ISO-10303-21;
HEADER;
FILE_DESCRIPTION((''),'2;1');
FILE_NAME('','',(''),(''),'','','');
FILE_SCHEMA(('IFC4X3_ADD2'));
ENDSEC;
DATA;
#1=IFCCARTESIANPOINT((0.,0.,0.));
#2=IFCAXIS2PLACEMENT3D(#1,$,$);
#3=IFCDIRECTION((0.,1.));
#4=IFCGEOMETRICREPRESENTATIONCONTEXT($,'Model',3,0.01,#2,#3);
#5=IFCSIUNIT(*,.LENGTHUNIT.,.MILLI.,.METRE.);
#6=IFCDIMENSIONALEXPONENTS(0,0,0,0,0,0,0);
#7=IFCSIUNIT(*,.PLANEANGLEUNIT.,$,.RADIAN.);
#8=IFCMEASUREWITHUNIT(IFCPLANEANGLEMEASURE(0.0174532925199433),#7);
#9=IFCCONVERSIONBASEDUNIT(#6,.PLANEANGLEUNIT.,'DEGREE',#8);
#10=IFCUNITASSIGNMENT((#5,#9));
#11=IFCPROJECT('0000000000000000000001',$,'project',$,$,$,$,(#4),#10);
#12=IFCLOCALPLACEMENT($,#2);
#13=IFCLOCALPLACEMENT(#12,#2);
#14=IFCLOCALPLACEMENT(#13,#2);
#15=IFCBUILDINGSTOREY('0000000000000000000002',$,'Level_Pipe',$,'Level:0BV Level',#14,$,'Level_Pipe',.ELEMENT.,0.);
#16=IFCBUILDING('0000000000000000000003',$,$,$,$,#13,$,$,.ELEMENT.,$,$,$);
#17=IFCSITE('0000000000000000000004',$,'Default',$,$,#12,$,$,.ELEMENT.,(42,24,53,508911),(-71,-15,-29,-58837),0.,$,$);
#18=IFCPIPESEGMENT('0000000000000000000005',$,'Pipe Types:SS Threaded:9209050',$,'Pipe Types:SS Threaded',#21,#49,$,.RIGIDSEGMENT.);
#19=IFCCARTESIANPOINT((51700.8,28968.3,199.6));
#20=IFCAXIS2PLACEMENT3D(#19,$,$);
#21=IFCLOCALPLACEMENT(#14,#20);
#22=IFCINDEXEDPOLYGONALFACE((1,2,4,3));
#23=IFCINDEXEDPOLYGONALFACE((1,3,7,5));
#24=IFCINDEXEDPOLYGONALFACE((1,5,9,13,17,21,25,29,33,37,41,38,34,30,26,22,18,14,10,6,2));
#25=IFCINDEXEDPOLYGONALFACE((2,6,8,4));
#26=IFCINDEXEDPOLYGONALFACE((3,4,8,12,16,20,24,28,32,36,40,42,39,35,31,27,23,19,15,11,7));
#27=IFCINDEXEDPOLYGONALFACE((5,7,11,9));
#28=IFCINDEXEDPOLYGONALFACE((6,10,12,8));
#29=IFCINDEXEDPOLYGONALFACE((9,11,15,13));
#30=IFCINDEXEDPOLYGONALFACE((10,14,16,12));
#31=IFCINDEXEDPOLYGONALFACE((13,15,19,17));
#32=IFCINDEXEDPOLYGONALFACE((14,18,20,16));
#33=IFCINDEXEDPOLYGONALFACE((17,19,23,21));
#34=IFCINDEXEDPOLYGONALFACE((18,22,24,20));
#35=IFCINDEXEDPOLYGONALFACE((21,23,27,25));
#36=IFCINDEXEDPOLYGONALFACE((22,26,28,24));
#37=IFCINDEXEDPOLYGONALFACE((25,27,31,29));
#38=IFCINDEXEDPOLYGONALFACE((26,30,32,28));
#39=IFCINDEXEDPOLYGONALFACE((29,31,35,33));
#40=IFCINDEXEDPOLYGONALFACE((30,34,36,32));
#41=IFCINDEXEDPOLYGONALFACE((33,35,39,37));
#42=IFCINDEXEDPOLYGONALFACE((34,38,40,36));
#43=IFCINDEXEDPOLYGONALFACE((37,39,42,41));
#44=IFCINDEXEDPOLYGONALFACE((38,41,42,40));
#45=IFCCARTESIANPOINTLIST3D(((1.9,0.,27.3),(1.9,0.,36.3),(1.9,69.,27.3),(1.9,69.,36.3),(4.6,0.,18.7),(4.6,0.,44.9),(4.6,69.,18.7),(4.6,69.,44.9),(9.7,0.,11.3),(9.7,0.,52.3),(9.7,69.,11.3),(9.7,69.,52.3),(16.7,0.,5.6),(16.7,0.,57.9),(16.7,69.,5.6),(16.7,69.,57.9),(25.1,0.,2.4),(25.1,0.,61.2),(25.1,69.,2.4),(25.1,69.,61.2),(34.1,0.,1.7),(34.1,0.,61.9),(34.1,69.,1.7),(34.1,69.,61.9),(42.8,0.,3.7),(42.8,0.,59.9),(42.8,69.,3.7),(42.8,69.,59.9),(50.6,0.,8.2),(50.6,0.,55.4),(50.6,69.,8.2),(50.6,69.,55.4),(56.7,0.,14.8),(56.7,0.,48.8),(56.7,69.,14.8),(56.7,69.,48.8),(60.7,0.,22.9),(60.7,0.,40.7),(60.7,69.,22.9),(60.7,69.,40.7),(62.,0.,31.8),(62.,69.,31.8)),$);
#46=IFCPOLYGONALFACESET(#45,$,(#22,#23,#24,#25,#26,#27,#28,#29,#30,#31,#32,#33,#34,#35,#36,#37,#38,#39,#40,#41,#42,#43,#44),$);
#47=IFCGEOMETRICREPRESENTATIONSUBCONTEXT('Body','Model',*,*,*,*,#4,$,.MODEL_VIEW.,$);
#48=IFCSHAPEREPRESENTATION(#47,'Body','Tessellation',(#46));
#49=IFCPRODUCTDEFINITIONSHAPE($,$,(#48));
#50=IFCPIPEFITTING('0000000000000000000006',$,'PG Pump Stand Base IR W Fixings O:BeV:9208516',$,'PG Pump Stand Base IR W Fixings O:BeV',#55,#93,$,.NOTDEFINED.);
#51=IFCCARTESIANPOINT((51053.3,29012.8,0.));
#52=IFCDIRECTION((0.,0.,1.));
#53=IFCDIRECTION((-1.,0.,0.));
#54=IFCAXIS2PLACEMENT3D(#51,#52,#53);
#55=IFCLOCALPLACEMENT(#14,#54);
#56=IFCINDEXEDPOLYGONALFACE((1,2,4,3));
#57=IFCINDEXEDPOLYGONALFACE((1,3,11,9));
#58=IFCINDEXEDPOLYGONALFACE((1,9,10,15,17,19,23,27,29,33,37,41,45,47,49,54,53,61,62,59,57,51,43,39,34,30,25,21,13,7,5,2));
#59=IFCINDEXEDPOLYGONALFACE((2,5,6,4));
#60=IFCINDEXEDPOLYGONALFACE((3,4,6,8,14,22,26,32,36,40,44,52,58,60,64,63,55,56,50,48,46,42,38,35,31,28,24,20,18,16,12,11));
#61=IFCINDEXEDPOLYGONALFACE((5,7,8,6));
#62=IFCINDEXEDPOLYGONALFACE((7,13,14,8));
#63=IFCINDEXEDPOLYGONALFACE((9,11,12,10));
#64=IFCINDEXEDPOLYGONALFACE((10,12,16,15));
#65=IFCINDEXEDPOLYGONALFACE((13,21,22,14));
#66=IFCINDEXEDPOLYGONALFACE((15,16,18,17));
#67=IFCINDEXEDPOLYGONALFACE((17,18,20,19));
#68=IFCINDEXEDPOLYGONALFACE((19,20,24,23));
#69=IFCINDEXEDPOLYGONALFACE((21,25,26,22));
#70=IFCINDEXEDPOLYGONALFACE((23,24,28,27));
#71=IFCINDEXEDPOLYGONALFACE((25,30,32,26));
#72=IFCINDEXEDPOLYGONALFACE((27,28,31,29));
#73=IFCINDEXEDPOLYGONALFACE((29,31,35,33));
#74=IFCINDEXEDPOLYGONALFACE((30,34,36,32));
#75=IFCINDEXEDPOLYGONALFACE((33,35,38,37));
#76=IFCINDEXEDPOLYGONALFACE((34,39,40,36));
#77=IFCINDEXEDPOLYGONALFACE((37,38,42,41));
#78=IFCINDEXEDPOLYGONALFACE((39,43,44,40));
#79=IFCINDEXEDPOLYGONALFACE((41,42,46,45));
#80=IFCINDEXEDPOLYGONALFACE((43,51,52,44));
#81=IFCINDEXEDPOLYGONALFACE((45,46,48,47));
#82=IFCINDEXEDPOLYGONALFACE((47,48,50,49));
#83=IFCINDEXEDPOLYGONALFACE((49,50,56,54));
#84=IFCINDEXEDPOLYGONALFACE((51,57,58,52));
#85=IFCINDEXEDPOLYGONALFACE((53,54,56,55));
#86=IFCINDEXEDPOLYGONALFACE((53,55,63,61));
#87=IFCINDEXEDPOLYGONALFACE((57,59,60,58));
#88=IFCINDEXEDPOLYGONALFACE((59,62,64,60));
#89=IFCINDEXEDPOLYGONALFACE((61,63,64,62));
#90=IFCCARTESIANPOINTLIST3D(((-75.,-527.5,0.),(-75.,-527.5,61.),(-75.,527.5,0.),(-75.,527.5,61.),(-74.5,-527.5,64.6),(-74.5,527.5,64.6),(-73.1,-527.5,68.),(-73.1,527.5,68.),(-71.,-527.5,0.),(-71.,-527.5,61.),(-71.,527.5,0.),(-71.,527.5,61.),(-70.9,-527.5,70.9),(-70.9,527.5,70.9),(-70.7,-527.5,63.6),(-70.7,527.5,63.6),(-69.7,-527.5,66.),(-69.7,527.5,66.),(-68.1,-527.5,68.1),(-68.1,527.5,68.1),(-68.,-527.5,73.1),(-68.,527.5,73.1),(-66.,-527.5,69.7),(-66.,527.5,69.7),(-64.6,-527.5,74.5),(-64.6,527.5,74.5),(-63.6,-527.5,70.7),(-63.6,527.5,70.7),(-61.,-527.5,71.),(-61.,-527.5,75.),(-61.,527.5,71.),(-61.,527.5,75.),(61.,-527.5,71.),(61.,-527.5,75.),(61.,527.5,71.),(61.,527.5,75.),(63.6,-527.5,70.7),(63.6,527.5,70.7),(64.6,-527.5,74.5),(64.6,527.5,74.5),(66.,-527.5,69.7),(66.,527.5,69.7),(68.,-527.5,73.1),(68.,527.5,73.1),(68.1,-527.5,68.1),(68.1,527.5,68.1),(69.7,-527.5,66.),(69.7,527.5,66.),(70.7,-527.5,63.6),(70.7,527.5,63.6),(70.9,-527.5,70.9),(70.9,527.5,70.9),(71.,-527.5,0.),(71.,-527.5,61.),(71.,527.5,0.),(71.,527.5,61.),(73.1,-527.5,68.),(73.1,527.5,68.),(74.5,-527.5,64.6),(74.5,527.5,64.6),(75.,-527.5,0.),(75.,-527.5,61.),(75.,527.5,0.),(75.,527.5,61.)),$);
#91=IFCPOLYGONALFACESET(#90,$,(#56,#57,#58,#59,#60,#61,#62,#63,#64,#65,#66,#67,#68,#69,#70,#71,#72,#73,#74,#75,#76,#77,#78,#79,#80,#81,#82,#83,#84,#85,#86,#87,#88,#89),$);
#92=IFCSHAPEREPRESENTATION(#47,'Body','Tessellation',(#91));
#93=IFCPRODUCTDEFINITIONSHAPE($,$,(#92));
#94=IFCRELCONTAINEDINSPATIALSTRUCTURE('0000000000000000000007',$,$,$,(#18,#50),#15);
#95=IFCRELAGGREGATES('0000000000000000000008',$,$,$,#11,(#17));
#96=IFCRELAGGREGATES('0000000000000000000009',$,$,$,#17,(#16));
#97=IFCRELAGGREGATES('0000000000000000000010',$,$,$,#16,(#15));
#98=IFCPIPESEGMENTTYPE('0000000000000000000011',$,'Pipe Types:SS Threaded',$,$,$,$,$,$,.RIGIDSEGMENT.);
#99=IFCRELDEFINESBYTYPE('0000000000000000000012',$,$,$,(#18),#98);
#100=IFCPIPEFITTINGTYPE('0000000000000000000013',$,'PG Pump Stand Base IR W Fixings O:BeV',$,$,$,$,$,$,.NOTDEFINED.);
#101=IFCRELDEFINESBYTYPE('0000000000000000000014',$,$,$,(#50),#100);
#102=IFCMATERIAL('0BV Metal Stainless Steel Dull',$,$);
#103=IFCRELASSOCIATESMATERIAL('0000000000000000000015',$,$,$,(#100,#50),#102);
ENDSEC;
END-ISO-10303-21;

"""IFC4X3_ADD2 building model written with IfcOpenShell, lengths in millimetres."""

from ifc_helpers import new_model, entity, si_unit, converted_unit, direction, frame, frame_2d, origin, place, context, subcontext, project, spatial, polyline, circle_curve, parameter, trimmed, segment, composite_curve, circle, outline, extrude, source, transform, mapped, material, type_object, type_shapes, element, save


model = new_model("IFC4X3_ADD2")

# Units and contexts
model_context = context("Model", 3, precision=0.01, world=origin(), true_north=direction((0.0, 1.0)))
body_context = subcontext(model_context, "Body", "Model", "MODEL_VIEW")
ifc_project = project(units=[si_unit("LENGTHUNIT", "METRE", prefix="MILLI"), converted_unit("PLANEANGLEUNIT", "DEGREE", entity("IfcPlaneAngleMeasure", 0.0174532925199433), si_unit("PLANEANGLEUNIT", "RADIAN"), dimensions=[0, 0, 0, 0, 0, 0, 0])], contexts=[model_context])

# Site, building, storey
site_placement = place(None, origin())
site = spatial("IfcSite", under=ifc_project, at=site_placement, Name="Default", CompositionType="ELEMENT", RefLatitude=(42, 24, 53, 508911), RefLongitude=(-71, -15, -29, -58837), RefElevation=0.0)
building_placement = place(site_placement, origin())
building = spatial("IfcBuilding", under=site, at=building_placement, CompositionType="ELEMENT")
storey_placement = place(building_placement, origin())
storey = spatial("IfcBuildingStorey", under=building, at=storey_placement, Name="Level_Pipe", ObjectType="Level:0BV Level", LongName="Level_Pipe", CompositionType="ELEMENT", Elevation=0.0)

# Pipe segment
pipe_segment_type = type_object("IfcPipeSegmentType", Name="Pipe Types:SS Threaded", PredefinedType="RIGIDSEGMENT")
pipe_segment_placement = place(storey_placement, frame((51700.8, 28968.3, 199.6)))
element("IfcPipeSegment", 1, at=pipe_segment_placement, inside=storey, type_object=pipe_segment_type, Name="Pipe Types:SS Threaded:9209050", ObjectType="Pipe Types:SS Threaded", PredefinedType="RIGIDSEGMENT", context=body_context, shape_type="SweptSolid", body=[
    extrude(circle(Radius=30.2, at=frame_2d((0.0, 0.0), x_axis=(1.0, 0.0))), frame((31.8, 0.0, 31.8), z_axis=(0.0, 1.0, 0.0), x_axis=(1.0, 0.0, 0.0)), (0.0, 0.0, 1.0), 69.0),
])

# Pipe fitting
ifc_material_1 = material(Name="0BV Metal Stainless Steel Dull")
pipe_fitting_type_1 = type_object("IfcPipeFittingType", Name="PG Pump Stand Base IR W Fixings O:BeV", PredefinedType="NOTDEFINED", material=ifc_material_1)
shared_shape_1 = source(origin(), body_context, "Body", "SweptSolid", [
    extrude(outline(composite_curve([segment(polyline([(71.0, -44.7), (75.0, -44.7)]), True, "CONTINUOUS"), segment(polyline([(75.0, -44.7), (75.0, 16.3)]), True, "CONTINUOUS"), segment(trimmed(circle_curve(frame_2d((61.0, 16.3), x_axis=(-1.0, 0.0)), 14.0), [parameter(180.0)], [parameter(270.0)], True, "PARAMETER"), True, "CONTINUOUS"), segment(polyline([(61.0, 30.3), (-61.0, 30.3)]), True, "CONTINUOUS"), segment(trimmed(circle_curve(frame_2d((-61.0, 16.3), x_axis=(-1.0, 0.0)), 14.0), [parameter(270.0)], [parameter(0.0)], True, "PARAMETER"), True, "CONTINUOUS"), segment(polyline([(-75.0, 16.3), (-75.0, -44.7)]), True, "CONTINUOUS"), segment(polyline([(-75.0, -44.7), (-71.0, -44.7)]), True, "CONTINUOUS"), segment(polyline([(-71.0, -44.7), (-71.0, 16.3)]), True, "CONTINUOUS"), segment(trimmed(circle_curve(frame_2d((-61.0, 16.3), x_axis=(-1.0, 0.0)), 10.0), [parameter(270.0)], [parameter(0.0)], True, "PARAMETER"), False, "CONTINUOUS"), segment(polyline([(-61.0, 26.3), (61.0, 26.3)]), True, "CONTINUOUS"), segment(trimmed(circle_curve(frame_2d((61.0, 16.3), x_axis=(-1.0, 0.0)), 10.0), [parameter(180.0)], [parameter(270.0)], True, "PARAMETER"), False, "CONTINUOUS"), segment(polyline([(71.0, 16.3), (71.0, -44.7)]), True, "CONTINUOUS")], self_intersect=False)), frame((0.0, -527.5, 44.7), z_axis=(0.0, 1.0, 0.0), x_axis=(-1.0, 0.0, 0.0)), (0.0, 0.0, 1.0), 1055.0),
])
type_shapes(pipe_fitting_type_1, [shared_shape_1])
pipe_fitting_1_placement = place(storey_placement, frame((51053.3, 29012.8, 0.0), z_axis=(0.0, 0.0, 1.0), x_axis=(-1.0, 0.0, 0.0)))
element("IfcPipeFitting", 2, at=pipe_fitting_1_placement, inside=storey, type_object=pipe_fitting_type_1, material=ifc_material_1, Name="PG Pump Stand Base IR W Fixings O:BeV:9208516", ObjectType="PG Pump Stand Base IR W Fixings O:BeV", PredefinedType="NOTDEFINED", context=body_context, shape_type="MappedRepresentation", body=[
    mapped(shared_shape_1, transform((0.0, 0.0, 0.0), scale=1.0)),
])

save(model, "model.ifc")
